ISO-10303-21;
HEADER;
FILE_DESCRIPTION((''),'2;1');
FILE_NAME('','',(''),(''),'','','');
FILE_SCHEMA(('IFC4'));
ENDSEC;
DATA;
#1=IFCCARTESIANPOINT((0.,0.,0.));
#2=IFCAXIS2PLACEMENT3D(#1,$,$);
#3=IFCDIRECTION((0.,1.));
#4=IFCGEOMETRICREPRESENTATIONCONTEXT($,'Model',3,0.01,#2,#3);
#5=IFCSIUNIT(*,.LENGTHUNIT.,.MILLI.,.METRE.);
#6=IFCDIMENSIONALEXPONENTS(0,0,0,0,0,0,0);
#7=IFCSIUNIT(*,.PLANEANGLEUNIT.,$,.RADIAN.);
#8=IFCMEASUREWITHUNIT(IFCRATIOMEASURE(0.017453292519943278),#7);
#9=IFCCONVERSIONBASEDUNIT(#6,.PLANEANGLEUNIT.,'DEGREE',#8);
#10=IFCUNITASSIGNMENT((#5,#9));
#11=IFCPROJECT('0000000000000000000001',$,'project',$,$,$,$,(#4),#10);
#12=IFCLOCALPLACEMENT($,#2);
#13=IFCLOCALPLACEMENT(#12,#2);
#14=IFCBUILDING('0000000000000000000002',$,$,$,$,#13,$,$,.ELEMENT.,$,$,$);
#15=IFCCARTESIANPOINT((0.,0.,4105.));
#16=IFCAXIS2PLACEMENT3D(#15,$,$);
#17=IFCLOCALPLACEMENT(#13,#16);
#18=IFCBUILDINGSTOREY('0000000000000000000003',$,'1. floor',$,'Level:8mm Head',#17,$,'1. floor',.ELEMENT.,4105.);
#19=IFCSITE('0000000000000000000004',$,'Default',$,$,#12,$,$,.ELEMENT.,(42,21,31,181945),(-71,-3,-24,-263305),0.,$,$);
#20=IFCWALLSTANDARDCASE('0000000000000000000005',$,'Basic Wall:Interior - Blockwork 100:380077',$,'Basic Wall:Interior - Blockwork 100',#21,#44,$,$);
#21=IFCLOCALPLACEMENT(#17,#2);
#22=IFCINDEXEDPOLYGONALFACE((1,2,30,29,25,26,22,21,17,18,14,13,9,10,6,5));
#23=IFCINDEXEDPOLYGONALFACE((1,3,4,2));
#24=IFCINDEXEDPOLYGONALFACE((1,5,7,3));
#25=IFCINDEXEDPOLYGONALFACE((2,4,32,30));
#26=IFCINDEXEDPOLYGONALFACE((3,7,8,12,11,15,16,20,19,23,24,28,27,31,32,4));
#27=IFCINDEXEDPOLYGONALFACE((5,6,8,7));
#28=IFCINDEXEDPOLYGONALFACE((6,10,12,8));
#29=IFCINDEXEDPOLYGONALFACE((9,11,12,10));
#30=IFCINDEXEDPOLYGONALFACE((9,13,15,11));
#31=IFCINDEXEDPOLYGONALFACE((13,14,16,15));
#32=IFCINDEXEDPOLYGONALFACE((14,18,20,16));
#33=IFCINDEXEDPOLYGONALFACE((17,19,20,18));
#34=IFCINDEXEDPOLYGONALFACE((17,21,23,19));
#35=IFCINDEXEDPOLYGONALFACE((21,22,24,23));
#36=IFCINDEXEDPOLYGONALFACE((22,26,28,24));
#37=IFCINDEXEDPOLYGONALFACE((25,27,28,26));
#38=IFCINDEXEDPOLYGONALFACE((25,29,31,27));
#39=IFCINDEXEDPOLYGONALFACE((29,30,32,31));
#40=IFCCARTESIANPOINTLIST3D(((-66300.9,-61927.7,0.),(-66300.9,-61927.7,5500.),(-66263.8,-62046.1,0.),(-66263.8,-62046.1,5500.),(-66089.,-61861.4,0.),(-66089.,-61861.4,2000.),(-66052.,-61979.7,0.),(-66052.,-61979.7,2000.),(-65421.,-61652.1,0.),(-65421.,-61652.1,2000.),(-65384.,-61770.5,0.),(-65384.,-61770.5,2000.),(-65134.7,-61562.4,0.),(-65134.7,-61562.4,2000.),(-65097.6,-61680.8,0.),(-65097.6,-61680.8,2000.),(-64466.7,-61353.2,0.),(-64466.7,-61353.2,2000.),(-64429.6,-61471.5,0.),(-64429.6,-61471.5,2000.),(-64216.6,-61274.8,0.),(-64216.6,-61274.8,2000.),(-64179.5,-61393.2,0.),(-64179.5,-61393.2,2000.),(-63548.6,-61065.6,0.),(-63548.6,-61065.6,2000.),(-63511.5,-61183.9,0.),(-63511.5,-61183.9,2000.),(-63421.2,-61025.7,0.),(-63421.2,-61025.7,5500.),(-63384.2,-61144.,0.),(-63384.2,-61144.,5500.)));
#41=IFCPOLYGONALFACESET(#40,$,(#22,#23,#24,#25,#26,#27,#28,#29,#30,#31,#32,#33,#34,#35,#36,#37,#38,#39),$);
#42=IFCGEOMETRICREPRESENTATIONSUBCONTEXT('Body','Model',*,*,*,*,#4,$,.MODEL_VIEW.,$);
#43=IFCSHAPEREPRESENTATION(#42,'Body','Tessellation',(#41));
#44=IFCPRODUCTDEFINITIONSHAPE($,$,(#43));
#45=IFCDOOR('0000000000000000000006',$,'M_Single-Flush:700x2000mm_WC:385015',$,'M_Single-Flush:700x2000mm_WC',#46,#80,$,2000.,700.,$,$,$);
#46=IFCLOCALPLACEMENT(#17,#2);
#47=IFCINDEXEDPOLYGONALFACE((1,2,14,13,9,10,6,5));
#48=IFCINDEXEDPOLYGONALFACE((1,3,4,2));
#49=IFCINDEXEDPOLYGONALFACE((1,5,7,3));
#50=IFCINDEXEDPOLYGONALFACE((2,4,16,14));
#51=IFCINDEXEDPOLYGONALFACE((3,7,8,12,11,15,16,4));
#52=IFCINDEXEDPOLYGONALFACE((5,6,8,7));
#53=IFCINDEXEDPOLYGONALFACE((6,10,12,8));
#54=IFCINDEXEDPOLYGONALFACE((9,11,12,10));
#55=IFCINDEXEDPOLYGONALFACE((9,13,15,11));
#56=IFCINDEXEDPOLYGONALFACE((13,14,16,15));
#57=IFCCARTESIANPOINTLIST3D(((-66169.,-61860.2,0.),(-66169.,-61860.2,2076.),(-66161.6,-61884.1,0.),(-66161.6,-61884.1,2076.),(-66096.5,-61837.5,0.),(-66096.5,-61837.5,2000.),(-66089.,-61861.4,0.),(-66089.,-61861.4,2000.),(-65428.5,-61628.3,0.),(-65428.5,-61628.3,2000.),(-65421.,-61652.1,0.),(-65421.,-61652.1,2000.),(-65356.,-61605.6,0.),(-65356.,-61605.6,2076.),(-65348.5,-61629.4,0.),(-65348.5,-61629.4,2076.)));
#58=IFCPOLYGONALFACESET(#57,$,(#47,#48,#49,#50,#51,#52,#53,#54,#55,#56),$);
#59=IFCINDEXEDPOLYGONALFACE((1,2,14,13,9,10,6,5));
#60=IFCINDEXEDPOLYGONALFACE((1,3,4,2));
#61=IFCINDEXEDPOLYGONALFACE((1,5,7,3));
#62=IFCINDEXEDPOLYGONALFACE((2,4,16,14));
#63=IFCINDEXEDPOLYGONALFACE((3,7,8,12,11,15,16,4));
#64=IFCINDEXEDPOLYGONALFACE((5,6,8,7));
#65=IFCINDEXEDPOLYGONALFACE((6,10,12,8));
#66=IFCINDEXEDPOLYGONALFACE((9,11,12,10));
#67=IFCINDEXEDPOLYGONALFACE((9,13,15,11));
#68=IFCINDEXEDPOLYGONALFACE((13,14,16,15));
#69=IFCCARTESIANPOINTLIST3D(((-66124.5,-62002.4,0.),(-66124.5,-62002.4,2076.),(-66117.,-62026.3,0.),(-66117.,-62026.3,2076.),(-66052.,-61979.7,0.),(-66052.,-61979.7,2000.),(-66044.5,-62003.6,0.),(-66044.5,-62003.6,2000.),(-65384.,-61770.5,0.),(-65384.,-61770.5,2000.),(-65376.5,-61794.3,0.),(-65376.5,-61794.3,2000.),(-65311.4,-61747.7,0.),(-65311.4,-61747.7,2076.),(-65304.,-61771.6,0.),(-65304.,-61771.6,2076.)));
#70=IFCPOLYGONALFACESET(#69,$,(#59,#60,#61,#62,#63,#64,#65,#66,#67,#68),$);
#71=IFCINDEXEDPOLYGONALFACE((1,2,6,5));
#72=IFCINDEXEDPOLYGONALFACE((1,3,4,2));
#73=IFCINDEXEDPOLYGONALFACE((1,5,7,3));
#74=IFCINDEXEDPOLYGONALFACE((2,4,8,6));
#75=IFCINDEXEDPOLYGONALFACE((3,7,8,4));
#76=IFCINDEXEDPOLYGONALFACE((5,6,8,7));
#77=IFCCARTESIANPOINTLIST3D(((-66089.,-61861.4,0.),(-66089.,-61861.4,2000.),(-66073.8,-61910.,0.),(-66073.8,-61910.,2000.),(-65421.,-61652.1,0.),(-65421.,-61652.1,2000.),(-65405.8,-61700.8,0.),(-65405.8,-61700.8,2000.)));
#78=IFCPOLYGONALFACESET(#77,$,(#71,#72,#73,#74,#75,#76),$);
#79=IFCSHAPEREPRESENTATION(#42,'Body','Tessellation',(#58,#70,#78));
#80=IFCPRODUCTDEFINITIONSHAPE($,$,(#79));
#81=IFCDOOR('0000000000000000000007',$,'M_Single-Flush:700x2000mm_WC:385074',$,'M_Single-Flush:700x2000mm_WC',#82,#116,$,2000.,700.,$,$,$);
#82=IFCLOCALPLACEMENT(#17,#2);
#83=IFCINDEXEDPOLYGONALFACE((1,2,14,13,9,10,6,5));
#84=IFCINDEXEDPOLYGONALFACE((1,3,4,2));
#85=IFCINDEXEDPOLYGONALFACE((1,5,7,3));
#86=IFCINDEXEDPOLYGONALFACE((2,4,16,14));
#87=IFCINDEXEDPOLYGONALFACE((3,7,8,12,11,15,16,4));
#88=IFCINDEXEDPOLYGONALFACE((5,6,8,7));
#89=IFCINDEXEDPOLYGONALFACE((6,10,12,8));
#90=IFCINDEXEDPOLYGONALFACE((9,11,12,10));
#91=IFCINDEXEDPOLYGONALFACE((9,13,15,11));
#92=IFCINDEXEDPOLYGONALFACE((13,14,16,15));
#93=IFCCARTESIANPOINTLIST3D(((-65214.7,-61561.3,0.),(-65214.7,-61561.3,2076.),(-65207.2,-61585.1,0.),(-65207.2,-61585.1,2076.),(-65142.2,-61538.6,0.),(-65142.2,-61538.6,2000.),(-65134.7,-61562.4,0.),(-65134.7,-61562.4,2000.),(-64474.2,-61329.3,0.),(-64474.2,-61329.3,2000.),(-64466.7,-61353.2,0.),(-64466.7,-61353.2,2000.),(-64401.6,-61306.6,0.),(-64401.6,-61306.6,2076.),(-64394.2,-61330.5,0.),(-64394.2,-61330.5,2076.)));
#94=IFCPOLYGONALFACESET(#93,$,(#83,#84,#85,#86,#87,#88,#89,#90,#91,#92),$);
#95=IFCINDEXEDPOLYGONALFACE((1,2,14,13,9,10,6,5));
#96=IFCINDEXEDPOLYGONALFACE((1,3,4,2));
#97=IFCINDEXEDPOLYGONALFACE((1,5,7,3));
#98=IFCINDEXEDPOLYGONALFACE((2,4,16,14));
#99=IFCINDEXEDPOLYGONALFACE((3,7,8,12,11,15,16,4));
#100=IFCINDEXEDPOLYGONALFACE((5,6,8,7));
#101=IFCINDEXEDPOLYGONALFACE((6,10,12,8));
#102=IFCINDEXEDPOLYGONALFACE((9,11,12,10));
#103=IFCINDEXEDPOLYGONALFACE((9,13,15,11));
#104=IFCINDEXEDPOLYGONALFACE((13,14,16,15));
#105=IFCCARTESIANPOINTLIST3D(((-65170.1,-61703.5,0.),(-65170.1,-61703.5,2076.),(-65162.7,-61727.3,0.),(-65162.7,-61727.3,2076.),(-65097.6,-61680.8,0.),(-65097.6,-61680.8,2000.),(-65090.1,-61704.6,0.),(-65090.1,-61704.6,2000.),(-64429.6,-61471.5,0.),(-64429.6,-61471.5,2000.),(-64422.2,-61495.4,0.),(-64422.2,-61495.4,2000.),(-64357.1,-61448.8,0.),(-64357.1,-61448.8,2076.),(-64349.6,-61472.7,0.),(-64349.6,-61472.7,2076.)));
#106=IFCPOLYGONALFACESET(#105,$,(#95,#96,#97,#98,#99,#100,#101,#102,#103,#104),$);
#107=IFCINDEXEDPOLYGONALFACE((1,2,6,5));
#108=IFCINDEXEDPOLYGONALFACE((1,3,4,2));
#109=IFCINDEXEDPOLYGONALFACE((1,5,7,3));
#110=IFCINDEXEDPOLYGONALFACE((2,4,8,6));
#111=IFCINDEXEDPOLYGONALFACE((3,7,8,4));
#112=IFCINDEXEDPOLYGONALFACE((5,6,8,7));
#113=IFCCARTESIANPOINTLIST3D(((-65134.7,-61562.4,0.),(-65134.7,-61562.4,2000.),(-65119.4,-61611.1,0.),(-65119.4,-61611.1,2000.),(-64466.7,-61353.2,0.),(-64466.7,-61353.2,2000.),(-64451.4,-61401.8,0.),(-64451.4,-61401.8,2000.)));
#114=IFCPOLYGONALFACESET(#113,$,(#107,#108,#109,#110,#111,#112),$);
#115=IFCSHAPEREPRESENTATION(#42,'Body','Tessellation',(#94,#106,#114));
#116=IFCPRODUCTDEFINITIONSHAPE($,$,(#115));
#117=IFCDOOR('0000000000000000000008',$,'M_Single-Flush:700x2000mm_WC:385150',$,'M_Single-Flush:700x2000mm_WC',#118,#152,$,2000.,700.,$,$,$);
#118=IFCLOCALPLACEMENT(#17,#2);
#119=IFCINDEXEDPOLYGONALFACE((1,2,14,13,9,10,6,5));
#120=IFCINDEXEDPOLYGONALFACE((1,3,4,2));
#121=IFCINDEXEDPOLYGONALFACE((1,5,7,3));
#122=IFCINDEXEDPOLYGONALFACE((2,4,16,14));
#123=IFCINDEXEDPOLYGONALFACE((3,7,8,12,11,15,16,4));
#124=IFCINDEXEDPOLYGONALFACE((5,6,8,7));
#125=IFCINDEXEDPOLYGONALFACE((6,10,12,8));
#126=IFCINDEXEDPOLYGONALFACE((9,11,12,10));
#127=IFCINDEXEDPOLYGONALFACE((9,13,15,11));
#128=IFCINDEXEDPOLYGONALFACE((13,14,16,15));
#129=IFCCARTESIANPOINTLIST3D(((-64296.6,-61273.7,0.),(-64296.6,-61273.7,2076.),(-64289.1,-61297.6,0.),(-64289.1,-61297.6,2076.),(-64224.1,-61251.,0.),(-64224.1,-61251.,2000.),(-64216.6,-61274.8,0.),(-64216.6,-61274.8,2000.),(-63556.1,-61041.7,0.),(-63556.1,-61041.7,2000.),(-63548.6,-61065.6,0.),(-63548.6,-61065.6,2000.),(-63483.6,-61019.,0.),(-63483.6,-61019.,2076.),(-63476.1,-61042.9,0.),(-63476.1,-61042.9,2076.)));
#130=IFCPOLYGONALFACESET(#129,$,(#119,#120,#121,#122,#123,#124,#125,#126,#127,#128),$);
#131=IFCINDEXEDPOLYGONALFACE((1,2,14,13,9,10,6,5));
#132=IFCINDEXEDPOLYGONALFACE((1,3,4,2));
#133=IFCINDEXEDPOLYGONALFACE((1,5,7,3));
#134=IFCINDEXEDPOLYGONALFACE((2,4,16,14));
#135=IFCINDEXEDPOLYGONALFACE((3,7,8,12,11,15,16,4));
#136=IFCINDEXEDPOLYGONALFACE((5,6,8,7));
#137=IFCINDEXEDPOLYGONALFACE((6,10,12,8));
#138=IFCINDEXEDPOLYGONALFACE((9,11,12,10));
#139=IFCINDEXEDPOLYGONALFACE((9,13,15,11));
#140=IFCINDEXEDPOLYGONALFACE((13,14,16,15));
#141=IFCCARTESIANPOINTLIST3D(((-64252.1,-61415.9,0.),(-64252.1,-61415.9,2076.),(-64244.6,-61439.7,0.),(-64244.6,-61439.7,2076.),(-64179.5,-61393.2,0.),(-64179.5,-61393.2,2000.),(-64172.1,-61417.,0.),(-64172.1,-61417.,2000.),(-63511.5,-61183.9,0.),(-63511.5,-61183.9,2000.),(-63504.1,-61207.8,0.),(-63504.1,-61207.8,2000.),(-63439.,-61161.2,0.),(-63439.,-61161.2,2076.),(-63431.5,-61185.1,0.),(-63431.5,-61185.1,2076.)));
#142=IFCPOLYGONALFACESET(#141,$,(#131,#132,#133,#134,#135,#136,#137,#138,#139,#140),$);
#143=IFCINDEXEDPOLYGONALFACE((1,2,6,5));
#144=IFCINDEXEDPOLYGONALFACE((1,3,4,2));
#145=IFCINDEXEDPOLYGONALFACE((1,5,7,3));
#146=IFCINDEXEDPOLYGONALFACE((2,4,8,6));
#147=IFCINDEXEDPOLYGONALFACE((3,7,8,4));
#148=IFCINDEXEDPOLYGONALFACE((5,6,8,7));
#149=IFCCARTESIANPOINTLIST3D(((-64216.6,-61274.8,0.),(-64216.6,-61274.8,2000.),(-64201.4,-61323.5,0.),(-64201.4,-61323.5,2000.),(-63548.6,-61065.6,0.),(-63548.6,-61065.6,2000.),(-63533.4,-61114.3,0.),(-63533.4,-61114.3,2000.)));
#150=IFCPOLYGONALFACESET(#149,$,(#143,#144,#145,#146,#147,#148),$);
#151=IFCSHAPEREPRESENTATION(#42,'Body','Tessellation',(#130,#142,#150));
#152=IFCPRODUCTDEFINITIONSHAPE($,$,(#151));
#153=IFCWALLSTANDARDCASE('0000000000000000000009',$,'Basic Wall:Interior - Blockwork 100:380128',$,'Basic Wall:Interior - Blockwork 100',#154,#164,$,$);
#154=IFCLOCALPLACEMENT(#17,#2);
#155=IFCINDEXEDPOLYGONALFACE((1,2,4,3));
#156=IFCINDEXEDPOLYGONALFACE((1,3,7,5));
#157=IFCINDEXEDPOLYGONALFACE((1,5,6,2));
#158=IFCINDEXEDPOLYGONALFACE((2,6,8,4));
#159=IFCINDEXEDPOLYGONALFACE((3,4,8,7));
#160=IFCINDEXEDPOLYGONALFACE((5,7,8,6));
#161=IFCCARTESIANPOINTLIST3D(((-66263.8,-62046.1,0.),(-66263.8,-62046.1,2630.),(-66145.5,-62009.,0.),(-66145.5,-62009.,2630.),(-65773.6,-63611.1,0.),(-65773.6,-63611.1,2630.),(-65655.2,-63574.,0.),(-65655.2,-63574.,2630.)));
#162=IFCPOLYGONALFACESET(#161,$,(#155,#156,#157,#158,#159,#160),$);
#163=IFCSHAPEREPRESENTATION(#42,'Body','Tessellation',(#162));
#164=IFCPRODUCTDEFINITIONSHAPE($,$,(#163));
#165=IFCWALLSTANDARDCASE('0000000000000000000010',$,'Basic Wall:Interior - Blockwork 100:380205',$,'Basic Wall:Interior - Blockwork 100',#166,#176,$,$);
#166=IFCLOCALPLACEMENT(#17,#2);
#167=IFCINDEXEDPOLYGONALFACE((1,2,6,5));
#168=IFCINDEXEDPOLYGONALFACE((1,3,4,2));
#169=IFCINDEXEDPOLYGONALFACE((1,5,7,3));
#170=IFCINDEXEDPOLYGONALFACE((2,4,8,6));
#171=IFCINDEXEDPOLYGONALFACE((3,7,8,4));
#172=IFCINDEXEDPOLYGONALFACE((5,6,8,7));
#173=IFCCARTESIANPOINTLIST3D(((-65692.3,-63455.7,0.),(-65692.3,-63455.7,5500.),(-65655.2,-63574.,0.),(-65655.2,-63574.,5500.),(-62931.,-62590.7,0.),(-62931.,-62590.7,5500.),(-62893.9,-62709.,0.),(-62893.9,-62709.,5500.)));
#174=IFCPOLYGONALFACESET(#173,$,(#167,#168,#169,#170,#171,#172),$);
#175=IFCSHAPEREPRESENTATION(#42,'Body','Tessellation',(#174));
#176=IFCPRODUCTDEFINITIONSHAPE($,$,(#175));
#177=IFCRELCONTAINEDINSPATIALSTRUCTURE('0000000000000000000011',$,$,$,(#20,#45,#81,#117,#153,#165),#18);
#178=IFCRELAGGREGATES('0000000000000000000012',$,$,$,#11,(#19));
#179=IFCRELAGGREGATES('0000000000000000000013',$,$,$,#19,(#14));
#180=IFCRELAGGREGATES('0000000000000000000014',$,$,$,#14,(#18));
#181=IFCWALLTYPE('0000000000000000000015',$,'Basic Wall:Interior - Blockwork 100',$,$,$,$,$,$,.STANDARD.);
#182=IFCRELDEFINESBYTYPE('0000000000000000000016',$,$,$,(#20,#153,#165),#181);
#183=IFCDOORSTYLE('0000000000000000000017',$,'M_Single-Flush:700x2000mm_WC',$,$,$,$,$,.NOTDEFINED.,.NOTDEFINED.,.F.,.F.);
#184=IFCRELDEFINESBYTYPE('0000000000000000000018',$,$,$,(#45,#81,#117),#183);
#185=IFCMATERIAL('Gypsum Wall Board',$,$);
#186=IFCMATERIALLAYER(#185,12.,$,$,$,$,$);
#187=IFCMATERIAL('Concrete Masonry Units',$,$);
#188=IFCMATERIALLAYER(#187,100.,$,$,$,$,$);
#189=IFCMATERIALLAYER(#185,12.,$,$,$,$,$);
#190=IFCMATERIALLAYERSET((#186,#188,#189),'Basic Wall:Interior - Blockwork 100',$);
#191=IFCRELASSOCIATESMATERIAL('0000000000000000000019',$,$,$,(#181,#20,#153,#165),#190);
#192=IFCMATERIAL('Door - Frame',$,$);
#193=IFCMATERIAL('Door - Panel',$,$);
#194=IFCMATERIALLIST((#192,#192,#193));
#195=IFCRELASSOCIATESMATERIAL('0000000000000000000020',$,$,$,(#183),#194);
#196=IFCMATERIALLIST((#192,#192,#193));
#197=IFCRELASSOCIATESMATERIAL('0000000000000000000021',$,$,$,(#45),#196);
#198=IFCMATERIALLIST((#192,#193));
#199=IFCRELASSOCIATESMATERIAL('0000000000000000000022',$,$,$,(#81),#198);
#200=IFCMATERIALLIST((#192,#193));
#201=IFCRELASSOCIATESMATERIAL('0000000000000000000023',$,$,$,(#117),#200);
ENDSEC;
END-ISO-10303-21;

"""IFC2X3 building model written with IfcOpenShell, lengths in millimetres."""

from ifc_helpers import new_model, entity, si_unit, converted_unit, direction, frame, frame_2d, origin, origin_2d_with_axis, place, context, subcontext, project, spatial, polyline, rectangle, outline, extrude, source, transform, mapped, material, material_list, layer, layer_set, layer_usage, type_object, type_shapes, element, fill, save


model = new_model("IFC2X3")

# Units and contexts
model_context = context("Model", 3, precision=0.01, world=origin(), true_north=direction((0.0, 1.0)))
body_context = subcontext(model_context, "Body", "Model", "MODEL_VIEW")
ifc_project = project(units=[si_unit("LENGTHUNIT", "METRE", prefix="MILLI"), converted_unit("PLANEANGLEUNIT", "DEGREE", entity("IfcRatioMeasure", 0.017453292519943278), si_unit("PLANEANGLEUNIT", "RADIAN"), dimensions=[0, 0, 0, 0, 0, 0, 0])], contexts=[model_context])

# Site, building, storey
site_placement = place(None, origin())
site = spatial("IfcSite", under=ifc_project, at=site_placement, Name="Default", CompositionType="ELEMENT", RefLatitude=(42, 21, 31, 181945), RefLongitude=(-71, -3, -24, -263305), RefElevation=0.0)
building_placement = place(site_placement, origin())
building = spatial("IfcBuilding", under=site, at=building_placement, CompositionType="ELEMENT")
storey_placement = place(building_placement, frame((0.0, 0.0, 4105.0)))
storey = spatial("IfcBuildingStorey", under=building, at=storey_placement, Name="1. floor", ObjectType="Level:8mm Head", LongName="1. floor", CompositionType="ELEMENT", Elevation=4105.0)

# Shared definitions
ifc_material_1 = material(Name="Gypsum Wall Board")

# Shared definitions
ifc_layer_1 = layer(ifc_material_1, 12.0)
ifc_material_2 = material(Name="Concrete Masonry Units")
ifc_layer_2 = layer(ifc_material_2, 100.0)
ifc_layer_3 = layer(ifc_material_1, 12.0)
ifc_layer_set_1 = layer_set([ifc_layer_1, ifc_layer_2, ifc_layer_3], Name="Basic Wall:Interior - Blockwork 100")
wall_type_1 = type_object("IfcWallType", Name="Basic Wall:Interior - Blockwork 100", PredefinedType="STANDARD", material=ifc_layer_set_1)
ifc_material_3 = material(Name="Door - Frame")
ifc_material_4 = material(Name="Door - Panel")

# Wall, openings, doors
ifc_layer_usage_1 = layer_usage(ifc_layer_set_1, "AXIS2", "NEGATIVE", 62.0)
wall_1_placement = place(storey_placement, frame((-63402.7, -61084.9, 0.0), z_axis=(0.0, 0.0, 1.0), x_axis=(-0.954277, -0.298924, 0.0)))
wall_1 = element("IfcWallStandardCase", 1, at=wall_1_placement, inside=storey, type_object=wall_type_1, material=ifc_layer_usage_1, Name="Basic Wall:Interior - Blockwork 100:380077", ObjectType="Basic Wall:Interior - Blockwork 100", context=body_context, shape_type="SweptSolid", body=[
    extrude(rectangle(XDim=3017.6, YDim=124.0, at=frame_2d((1508.8, 0.0), x_axis=(-1.0, 0.0))), origin(), (0.0, 0.0, 1.0), 5500.0),
])
opening_1_placement = place(wall_1_placement, frame((2795.6, 62.0, 0.0)))
opening_1 = element("IfcOpeningElement", 2, at=opening_1_placement, cuts=wall_1, ObjectType="Opening", context=body_context, shape_type="SweptSolid", body=[
    extrude(rectangle(XDim=700.0, YDim=2000.0, at=frame_2d((1000.0, 350.0), x_axis=(0.0, 1.0))), frame((0.0, 0.0, 0.0), z_axis=(0.0, -1.0, 0.0), x_axis=(0.0, 0.0, 1.0)), (0.0, 0.0, 1.0), 124.0),
])
opening_2_placement = place(wall_1_placement, frame((1795.5, 62.0, 0.0)))
opening_2 = element("IfcOpeningElement", 3, at=opening_2_placement, cuts=wall_1, ObjectType="Opening", context=body_context, shape_type="SweptSolid", body=[
    extrude(rectangle(XDim=700.0, YDim=2000.0, at=frame_2d((1000.0, 350.0), x_axis=(0.0, 1.0))), frame((0.0, 0.0, 0.0), z_axis=(0.0, -1.0, 0.0), x_axis=(0.0, 0.0, 1.0)), (0.0, 0.0, 1.0), 124.0),
])
opening_3_placement = place(wall_1_placement, frame((833.5, 62.0, 0.0)))
opening_3 = element("IfcOpeningElement", 4, at=opening_3_placement, cuts=wall_1, ObjectType="Opening", context=body_context, shape_type="SweptSolid", body=[
    extrude(rectangle(XDim=700.0, YDim=2000.0, at=frame_2d((1000.0, 350.0), x_axis=(0.0, 1.0))), frame((0.0, 0.0, 0.0), z_axis=(0.0, -1.0, 0.0), x_axis=(0.0, 0.0, 1.0)), (0.0, 0.0, 1.0), 124.0),
])
ifc_material_list_1 = material_list([ifc_material_3, ifc_material_3, ifc_material_4])
ifc_material_list_2 = material_list([ifc_material_3, ifc_material_3, ifc_material_4])
door_style_1 = type_object("IfcDoorStyle", Name="M_Single-Flush:700x2000mm_WC", ConstructionType="NOTDEFINED", OperationType="NOTDEFINED", ParameterTakesPrecedence=False, Sizeable=False, material=ifc_material_list_2)
shared_shape_1 = source(origin(), body_context, "Body", "SweptSolid", [
    extrude(outline(polyline([(-426.0, -1057.0), (426.0, -1057.0), (426.0, 1019.0), (350.0, 1019.0), (350.0, -981.0), (-350.0, -981.0), (-350.0, 1019.0), (-426.0, 1019.0), (-426.0, -1057.0)])), frame((350.0, 124.0, 1019.0), z_axis=(0.0, 1.0, 0.0), x_axis=(1.0, 0.0, 0.0)), (0.0, 0.0, 1.0), 25.0),
    extrude(outline(polyline([(-1057.0, -426.0), (1019.0, -426.0), (1019.0, -350.0), (-981.0, -350.0), (-981.0, 350.0), (1019.0, 350.0), (1019.0, 426.0), (-1057.0, 426.0), (-1057.0, -426.0)])), frame((350.0, -25.0, 1019.0), z_axis=(0.0, 1.0, 0.0), x_axis=(0.0, 0.0, -1.0)), (0.0, 0.0, 1.0), 25.0),
    extrude(rectangle(XDim=51.0, YDim=700.0, at=origin_2d_with_axis()), frame((350.0, 98.5, 0.0), z_axis=(0.0, 0.0, 1.0), x_axis=(0.0, 1.0, 0.0)), (0.0, 0.0, 1.0), 2000.0),
])
type_shapes(door_style_1, [shared_shape_1])
door_1_placement = place(opening_1_placement, frame((0.0, 0.0, 0.0), z_axis=(0.0, 0.0, 1.0), x_axis=(-1.0, 0.0, 0.0)))
door_1 = element("IfcDoor", 5, at=door_1_placement, inside=storey, type_object=door_style_1, material=ifc_material_list_1, Name="M_Single-Flush:700x2000mm_WC:385015", ObjectType="M_Single-Flush:700x2000mm_WC", OverallHeight=2000.0, OverallWidth=700.0, context=body_context, shape_type="MappedRepresentation", body=[
    mapped(shared_shape_1, transform((0.0, 0.0, 0.0), scale=1.0)),
])
fill(opening_1, door_1)
ifc_material_list_3 = material_list([ifc_material_3, ifc_material_4])
door_2_placement = place(opening_2_placement, frame((0.0, 0.0, 0.0), z_axis=(0.0, 0.0, 1.0), x_axis=(-1.0, 0.0, 0.0)))
door_2 = element("IfcDoor", 6, at=door_2_placement, inside=storey, type_object=door_style_1, material=ifc_material_list_3, Name="M_Single-Flush:700x2000mm_WC:385074", ObjectType="M_Single-Flush:700x2000mm_WC", OverallHeight=2000.0, OverallWidth=700.0, context=body_context, shape_type="MappedRepresentation", body=[
    mapped(shared_shape_1, transform((0.0, 0.0, 0.0), scale=1.0)),
])
fill(opening_2, door_2)
ifc_material_list_4 = material_list([ifc_material_3, ifc_material_4])
door_3_placement = place(opening_3_placement, frame((0.0, 0.0, 0.0), z_axis=(0.0, 0.0, 1.0), x_axis=(-1.0, 0.0, 0.0)))
door_3 = element("IfcDoor", 7, at=door_3_placement, inside=storey, type_object=door_style_1, material=ifc_material_list_4, Name="M_Single-Flush:700x2000mm_WC:385150", ObjectType="M_Single-Flush:700x2000mm_WC", OverallHeight=2000.0, OverallWidth=700.0, context=body_context, shape_type="MappedRepresentation", body=[
    mapped(shared_shape_1, transform((0.0, 0.0, 0.0), scale=1.0)),
])
fill(opening_3, door_3)

# Walls
ifc_layer_usage_2 = layer_usage(ifc_layer_set_1, "AXIS2", "NEGATIVE", 62.0)
wall_2_placement = place(storey_placement, frame((-66204.6, -62027.5, 0.0), z_axis=(0.0, 0.0, 1.0), x_axis=(0.298924, -0.954277, 0.0)))
element("IfcWallStandardCase", 8, at=wall_2_placement, inside=storey, type_object=wall_type_1, material=ifc_layer_usage_2, Name="Basic Wall:Interior - Blockwork 100:380128", ObjectType="Basic Wall:Interior - Blockwork 100", context=body_context, shape_type="SweptSolid", body=[
    extrude(rectangle(XDim=1640.0, YDim=124.0, at=frame_2d((820.0, 0.0), x_axis=(-1.0, 0.0))), origin(), (0.0, 0.0, 1.0), 2630.0),
])
ifc_layer_usage_3 = layer_usage(ifc_layer_set_1, "AXIS2", "NEGATIVE", 62.0)
wall_3_placement = place(storey_placement, frame((-62912.5, -62649.9, 0.0), z_axis=(0.0, 0.0, 1.0), x_axis=(-0.954277, -0.298924, 0.0)))
element("IfcWallStandardCase", 9, at=wall_3_placement, inside=storey, type_object=wall_type_1, material=ifc_layer_usage_3, Name="Basic Wall:Interior - Blockwork 100:380205", ObjectType="Basic Wall:Interior - Blockwork 100", context=body_context, shape_type="SweptSolid", body=[
    extrude(rectangle(XDim=2893.6, YDim=124.0, at=frame_2d((1446.8, 0.0), x_axis=(-1.0, 0.0))), origin(), (0.0, 0.0, 1.0), 5500.0),
])

save(model, "model.ifc")
